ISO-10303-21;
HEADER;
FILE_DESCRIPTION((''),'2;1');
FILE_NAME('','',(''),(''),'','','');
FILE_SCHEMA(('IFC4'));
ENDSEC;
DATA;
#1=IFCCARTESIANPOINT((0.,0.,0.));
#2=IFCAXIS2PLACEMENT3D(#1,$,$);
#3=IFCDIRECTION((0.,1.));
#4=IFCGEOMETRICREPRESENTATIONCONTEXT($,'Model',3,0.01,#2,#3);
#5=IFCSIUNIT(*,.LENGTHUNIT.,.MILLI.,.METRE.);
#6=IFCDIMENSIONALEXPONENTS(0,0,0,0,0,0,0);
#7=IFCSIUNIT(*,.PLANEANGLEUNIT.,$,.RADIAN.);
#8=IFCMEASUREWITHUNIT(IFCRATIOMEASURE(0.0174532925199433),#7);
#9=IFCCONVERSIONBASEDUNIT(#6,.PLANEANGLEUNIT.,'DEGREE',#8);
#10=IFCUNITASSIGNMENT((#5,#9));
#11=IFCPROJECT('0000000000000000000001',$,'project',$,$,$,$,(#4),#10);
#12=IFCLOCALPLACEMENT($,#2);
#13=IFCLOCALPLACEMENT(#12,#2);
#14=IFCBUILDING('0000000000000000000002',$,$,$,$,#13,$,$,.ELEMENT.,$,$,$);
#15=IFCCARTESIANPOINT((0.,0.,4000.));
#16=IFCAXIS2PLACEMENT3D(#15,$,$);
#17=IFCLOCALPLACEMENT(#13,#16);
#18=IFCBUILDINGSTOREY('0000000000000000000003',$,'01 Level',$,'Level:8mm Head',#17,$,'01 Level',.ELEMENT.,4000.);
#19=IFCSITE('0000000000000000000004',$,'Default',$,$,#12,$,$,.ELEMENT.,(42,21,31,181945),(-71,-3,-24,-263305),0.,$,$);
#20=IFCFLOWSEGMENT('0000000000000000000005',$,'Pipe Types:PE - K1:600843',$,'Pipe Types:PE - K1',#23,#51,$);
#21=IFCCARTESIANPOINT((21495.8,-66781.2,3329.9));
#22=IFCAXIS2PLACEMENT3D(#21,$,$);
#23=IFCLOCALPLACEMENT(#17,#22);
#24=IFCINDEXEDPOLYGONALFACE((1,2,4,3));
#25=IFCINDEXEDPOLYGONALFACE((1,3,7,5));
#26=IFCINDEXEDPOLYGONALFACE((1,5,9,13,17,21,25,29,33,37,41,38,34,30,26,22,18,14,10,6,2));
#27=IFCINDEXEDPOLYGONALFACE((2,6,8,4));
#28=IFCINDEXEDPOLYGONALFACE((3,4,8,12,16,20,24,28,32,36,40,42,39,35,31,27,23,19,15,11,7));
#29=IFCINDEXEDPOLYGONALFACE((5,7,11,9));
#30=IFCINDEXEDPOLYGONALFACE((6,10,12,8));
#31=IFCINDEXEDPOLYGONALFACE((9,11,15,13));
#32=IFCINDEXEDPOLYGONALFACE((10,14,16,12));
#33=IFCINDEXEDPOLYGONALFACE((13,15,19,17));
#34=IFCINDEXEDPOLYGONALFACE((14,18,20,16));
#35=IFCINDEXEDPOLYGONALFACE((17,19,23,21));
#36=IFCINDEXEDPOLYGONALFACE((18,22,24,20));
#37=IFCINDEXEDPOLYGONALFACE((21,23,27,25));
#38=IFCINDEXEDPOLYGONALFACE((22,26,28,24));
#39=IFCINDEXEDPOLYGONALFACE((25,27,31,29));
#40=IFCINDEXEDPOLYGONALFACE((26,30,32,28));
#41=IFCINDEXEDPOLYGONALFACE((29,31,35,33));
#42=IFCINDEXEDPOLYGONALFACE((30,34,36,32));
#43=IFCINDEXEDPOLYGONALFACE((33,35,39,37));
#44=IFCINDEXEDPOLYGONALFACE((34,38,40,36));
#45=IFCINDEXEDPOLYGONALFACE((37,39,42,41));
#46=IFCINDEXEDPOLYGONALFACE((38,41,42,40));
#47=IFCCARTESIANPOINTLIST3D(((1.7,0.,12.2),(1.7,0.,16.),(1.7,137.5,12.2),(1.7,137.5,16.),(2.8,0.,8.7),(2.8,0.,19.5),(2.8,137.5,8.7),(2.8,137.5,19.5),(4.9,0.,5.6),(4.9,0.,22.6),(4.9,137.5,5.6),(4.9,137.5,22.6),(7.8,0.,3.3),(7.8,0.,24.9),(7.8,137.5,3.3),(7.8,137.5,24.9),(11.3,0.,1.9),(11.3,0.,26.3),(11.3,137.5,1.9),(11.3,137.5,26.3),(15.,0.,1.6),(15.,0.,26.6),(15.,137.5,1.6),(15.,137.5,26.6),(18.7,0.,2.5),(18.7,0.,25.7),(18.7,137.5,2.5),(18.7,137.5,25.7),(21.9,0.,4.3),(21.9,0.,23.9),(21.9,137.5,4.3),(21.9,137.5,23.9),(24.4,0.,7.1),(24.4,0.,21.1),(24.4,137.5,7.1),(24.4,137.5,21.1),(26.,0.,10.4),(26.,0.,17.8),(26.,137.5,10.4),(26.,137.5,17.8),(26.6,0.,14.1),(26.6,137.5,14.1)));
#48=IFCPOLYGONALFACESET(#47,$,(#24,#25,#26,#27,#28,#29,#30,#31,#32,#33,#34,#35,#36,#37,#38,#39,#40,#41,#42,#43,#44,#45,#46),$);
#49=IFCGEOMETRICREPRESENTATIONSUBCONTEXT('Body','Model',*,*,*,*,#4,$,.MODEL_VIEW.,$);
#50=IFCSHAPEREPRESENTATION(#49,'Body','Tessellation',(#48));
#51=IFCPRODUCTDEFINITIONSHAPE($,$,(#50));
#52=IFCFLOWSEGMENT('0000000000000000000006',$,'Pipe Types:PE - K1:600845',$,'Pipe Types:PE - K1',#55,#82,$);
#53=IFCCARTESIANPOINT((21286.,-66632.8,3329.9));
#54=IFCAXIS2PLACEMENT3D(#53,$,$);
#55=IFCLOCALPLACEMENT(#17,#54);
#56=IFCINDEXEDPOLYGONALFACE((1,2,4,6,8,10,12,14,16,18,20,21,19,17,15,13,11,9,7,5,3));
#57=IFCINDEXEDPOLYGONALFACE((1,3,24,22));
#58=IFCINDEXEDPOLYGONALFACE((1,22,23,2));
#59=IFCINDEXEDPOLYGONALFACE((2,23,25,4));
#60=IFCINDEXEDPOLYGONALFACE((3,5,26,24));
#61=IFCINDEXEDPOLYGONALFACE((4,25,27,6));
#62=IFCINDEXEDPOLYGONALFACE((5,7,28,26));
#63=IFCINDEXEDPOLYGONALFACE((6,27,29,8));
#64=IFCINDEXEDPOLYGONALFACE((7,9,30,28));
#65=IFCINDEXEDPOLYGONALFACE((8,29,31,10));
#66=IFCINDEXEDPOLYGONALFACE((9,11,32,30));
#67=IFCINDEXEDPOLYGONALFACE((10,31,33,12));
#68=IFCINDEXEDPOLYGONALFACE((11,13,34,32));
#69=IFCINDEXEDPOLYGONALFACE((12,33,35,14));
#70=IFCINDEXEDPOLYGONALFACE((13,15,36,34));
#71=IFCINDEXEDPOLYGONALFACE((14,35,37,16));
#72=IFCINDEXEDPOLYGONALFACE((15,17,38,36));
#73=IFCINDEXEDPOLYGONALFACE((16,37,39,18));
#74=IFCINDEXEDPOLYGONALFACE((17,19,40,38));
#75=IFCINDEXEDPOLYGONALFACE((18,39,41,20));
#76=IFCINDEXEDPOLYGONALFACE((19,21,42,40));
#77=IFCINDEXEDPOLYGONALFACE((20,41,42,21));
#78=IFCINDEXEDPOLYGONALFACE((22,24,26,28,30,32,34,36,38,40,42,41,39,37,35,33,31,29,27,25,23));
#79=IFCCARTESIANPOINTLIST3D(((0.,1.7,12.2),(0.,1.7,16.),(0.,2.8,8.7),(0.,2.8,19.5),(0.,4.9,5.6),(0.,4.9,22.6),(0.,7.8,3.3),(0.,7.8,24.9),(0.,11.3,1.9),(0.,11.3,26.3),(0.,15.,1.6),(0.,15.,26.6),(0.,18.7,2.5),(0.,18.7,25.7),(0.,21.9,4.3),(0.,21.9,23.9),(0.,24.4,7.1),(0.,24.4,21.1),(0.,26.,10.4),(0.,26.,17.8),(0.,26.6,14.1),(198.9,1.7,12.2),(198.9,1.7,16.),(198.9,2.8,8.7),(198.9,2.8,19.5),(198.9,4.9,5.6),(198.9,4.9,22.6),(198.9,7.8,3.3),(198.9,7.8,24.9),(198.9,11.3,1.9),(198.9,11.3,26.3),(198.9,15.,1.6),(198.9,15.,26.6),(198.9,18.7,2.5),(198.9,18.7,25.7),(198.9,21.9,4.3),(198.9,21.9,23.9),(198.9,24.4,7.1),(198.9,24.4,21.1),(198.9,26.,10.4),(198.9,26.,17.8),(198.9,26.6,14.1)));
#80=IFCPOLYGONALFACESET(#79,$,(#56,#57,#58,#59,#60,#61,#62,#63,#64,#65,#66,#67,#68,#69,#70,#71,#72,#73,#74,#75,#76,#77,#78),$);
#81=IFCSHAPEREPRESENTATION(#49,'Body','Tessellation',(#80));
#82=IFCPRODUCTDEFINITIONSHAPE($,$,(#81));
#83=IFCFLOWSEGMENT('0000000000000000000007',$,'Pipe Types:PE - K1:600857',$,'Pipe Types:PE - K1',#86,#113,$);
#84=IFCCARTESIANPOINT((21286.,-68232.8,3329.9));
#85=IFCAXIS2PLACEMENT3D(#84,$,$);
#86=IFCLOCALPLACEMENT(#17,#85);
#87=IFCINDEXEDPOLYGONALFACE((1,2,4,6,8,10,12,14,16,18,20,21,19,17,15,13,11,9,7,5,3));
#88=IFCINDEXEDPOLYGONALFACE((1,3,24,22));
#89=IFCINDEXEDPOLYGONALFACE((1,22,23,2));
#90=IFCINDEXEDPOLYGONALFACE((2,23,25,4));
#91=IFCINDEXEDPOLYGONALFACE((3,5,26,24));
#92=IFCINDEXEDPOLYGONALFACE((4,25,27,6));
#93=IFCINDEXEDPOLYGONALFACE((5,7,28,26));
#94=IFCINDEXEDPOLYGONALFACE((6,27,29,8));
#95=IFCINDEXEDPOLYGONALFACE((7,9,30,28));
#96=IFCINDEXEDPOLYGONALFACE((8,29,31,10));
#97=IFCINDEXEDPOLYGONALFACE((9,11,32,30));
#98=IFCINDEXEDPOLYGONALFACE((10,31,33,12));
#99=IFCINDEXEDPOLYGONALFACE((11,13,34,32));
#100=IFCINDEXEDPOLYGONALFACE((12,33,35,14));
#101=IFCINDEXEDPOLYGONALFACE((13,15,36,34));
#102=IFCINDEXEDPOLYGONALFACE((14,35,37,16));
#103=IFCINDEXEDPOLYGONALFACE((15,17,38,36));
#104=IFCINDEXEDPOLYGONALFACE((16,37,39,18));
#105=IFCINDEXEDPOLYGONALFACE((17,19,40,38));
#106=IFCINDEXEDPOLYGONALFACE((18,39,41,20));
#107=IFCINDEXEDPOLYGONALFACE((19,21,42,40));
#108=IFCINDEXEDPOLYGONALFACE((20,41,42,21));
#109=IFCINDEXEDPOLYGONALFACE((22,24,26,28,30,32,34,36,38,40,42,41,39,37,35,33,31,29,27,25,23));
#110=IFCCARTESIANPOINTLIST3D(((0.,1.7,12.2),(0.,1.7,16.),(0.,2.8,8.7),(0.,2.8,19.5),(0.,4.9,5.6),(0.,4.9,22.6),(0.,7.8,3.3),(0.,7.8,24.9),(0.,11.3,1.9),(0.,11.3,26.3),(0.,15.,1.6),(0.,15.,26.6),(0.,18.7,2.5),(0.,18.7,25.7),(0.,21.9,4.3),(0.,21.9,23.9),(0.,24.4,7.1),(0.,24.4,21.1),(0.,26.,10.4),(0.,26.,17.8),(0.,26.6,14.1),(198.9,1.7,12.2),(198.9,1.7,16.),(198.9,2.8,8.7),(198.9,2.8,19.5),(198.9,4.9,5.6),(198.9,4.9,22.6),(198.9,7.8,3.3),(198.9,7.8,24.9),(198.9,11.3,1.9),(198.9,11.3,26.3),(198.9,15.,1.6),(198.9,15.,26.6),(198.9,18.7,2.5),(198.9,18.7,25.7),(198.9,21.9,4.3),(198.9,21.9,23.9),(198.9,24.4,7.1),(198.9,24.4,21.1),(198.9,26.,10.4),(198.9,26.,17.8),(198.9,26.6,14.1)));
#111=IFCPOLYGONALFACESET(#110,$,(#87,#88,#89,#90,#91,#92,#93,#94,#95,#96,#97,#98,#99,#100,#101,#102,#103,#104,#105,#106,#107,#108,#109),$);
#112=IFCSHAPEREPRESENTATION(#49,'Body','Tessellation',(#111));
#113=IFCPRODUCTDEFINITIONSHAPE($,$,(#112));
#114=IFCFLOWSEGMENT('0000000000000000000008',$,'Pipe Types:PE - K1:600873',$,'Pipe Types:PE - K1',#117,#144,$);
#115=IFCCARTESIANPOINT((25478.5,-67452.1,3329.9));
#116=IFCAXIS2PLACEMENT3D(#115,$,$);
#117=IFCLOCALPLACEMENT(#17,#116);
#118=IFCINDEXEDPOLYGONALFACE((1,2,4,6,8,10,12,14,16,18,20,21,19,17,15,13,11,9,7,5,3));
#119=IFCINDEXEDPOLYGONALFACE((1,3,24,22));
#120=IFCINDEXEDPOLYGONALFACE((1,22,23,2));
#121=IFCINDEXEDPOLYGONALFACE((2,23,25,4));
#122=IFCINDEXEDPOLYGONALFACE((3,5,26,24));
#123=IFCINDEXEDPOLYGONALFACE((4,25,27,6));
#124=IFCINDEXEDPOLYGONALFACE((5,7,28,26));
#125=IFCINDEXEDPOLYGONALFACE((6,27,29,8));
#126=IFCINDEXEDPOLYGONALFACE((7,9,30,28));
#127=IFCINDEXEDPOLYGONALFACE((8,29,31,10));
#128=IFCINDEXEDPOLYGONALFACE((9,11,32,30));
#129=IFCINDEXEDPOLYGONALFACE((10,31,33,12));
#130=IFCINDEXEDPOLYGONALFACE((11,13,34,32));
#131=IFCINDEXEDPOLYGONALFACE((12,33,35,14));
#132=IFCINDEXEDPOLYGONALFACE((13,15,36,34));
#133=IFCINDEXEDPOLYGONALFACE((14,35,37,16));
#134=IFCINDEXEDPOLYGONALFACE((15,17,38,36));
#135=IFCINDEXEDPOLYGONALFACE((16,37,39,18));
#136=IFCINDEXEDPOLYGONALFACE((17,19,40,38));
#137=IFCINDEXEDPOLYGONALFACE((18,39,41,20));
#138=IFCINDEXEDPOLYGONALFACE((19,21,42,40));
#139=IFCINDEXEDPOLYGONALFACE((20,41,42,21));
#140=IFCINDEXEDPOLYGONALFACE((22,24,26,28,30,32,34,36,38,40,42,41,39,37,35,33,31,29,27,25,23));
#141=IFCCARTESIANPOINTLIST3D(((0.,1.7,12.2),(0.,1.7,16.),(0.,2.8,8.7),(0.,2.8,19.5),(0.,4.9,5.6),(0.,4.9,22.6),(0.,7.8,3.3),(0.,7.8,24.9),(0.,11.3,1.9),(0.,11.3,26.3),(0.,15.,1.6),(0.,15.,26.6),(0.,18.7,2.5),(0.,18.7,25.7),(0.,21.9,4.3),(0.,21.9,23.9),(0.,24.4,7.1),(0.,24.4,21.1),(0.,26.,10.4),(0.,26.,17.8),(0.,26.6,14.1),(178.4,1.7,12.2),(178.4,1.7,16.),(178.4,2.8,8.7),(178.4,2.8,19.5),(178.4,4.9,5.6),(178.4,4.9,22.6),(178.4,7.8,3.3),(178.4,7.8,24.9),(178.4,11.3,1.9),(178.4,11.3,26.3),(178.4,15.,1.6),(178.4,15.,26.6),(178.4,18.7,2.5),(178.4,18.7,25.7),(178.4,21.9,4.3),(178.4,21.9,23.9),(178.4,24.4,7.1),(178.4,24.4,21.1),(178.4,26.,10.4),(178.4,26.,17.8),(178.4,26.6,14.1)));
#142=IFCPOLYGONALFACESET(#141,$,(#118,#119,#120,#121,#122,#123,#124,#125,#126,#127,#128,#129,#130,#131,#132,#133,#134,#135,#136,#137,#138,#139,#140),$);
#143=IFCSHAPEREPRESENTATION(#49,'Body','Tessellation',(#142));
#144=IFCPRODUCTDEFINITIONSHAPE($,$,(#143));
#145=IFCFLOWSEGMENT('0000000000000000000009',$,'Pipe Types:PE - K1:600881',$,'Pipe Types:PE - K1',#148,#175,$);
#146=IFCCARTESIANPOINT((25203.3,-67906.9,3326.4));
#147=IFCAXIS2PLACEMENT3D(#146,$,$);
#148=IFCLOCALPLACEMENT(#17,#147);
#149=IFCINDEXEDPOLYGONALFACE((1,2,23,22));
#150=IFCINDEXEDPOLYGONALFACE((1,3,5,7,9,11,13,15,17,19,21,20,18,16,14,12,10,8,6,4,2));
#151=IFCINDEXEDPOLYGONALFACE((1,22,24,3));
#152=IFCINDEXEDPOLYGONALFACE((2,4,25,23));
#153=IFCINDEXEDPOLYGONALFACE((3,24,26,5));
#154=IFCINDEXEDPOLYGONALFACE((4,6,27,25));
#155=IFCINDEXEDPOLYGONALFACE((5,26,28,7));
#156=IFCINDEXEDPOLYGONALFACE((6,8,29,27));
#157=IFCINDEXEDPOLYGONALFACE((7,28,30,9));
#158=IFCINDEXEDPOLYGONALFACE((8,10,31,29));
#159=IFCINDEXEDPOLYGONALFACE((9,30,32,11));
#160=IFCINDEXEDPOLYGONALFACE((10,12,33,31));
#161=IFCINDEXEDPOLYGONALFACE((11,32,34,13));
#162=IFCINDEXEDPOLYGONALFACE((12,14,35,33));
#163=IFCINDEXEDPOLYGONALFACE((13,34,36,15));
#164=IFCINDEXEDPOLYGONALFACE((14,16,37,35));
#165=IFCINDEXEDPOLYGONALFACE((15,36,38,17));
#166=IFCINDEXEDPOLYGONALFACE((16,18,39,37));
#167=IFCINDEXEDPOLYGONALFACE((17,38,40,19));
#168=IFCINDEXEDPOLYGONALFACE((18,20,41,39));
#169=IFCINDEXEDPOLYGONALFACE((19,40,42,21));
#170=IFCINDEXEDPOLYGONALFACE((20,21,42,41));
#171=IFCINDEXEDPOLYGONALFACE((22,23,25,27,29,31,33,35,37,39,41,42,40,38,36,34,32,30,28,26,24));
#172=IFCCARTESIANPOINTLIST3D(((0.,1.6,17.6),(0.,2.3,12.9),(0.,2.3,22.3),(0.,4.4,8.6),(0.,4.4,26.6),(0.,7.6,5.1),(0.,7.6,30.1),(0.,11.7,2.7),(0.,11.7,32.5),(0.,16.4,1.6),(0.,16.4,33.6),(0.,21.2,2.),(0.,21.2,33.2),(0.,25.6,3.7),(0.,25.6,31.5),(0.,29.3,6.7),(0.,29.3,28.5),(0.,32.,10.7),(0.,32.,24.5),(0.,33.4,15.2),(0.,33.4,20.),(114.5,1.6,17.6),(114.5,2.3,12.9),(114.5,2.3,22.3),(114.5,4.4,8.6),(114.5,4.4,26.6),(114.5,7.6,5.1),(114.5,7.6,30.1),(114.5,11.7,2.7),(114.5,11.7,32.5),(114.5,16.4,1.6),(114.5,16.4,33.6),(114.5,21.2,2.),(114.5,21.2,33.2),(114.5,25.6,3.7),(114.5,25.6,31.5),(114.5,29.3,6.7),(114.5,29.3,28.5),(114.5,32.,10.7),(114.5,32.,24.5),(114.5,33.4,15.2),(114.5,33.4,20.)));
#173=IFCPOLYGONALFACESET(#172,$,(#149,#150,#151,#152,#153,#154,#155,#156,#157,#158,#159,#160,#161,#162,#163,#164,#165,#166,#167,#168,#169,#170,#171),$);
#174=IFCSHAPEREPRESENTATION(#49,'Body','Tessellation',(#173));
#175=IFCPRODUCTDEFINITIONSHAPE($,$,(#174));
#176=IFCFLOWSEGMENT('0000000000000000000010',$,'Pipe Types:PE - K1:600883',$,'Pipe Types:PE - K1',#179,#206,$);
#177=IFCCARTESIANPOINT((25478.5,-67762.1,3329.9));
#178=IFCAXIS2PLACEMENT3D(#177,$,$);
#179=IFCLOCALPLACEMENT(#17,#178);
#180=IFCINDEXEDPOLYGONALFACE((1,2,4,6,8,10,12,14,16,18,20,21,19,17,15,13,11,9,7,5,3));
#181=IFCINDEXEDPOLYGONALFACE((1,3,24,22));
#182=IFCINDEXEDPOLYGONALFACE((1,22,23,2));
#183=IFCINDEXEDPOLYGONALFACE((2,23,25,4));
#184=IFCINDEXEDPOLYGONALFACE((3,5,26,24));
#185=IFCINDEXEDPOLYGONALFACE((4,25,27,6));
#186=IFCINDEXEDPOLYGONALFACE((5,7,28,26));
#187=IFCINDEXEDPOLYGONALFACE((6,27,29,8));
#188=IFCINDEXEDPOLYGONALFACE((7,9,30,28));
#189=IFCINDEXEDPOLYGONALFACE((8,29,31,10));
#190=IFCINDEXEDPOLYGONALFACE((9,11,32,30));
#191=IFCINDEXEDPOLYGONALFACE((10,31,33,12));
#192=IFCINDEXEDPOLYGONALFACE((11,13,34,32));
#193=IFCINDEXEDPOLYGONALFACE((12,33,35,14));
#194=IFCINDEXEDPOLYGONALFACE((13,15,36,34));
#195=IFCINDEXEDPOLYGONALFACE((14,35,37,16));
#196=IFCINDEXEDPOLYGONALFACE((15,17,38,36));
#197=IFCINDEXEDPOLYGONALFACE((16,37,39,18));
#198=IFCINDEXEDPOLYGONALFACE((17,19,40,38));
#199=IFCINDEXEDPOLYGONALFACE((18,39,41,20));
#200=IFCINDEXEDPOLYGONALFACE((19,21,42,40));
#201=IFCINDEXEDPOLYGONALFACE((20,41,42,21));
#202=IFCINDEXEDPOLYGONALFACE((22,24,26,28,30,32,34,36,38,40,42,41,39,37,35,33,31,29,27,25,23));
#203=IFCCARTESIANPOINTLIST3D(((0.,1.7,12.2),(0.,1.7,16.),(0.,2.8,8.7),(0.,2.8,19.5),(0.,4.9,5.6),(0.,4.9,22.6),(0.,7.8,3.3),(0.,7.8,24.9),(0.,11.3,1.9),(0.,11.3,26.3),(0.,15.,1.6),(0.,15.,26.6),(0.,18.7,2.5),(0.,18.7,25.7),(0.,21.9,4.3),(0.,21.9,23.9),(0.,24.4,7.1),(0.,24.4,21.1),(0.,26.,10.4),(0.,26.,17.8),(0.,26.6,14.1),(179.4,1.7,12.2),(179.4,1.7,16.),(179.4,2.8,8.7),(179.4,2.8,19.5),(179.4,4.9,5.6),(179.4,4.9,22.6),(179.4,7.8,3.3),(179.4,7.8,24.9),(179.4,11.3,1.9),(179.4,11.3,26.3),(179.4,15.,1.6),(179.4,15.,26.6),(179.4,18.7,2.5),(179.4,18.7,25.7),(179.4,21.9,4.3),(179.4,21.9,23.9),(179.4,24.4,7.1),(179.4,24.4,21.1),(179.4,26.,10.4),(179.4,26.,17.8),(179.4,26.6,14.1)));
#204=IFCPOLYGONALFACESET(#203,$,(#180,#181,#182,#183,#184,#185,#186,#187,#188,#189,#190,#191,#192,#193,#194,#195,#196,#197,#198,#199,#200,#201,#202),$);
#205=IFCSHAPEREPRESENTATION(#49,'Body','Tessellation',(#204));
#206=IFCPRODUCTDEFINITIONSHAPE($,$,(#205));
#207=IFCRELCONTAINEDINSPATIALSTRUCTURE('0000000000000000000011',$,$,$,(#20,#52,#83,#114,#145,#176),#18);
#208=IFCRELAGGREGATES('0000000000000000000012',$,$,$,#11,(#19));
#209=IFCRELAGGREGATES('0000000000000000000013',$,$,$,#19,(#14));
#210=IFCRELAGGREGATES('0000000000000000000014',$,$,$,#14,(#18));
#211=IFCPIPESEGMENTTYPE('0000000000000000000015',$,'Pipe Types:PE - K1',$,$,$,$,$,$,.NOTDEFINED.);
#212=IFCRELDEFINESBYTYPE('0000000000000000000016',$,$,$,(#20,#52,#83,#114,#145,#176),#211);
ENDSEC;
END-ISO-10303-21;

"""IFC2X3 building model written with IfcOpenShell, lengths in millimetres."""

from ifc_helpers import new_model, entity, si_unit, converted_unit, direction, frame, frame_2d, origin, origin_2d_with_axis, place, context, subcontext, project, spatial, circle, extrude, type_object, element, save


model = new_model("IFC2X3")

# Units and contexts
model_context = context("Model", 3, precision=0.01, world=origin(), true_north=direction((0.0, 1.0)))
body_context = subcontext(model_context, "Body", "Model", "MODEL_VIEW")
ifc_project = project(units=[si_unit("LENGTHUNIT", "METRE", prefix="MILLI"), converted_unit("PLANEANGLEUNIT", "DEGREE", entity("IfcRatioMeasure", 0.0174532925199433), si_unit("PLANEANGLEUNIT", "RADIAN"), dimensions=[0, 0, 0, 0, 0, 0, 0])], contexts=[model_context])

# Site, building, storey
site_placement = place(None, origin())
site = spatial("IfcSite", under=ifc_project, at=site_placement, Name="Default", CompositionType="ELEMENT", RefLatitude=(42, 21, 31, 181945), RefLongitude=(-71, -3, -24, -263305), RefElevation=0.0)
building_placement = place(site_placement, origin())
building = spatial("IfcBuilding", under=site, at=building_placement, CompositionType="ELEMENT")
storey_placement = place(building_placement, frame((0.0, 0.0, 4000.0)))
storey = spatial("IfcBuildingStorey", under=building, at=storey_placement, Name="01 Level", ObjectType="Level:8mm Head", LongName="01 Level", CompositionType="ELEMENT", Elevation=4000.0)

# Flow segments
pipe_segment_type = type_object("IfcPipeSegmentType", Name="Pipe Types:PE - K1", PredefinedType="NOTDEFINED")
flow_segment_1_placement = place(storey_placement, frame((21495.8, -66781.2, 3329.9)))
element("IfcFlowSegment", 1, at=flow_segment_1_placement, inside=storey, type_object=pipe_segment_type, Name="Pipe Types:PE - K1:600843", ObjectType="Pipe Types:PE - K1", context=body_context, shape_type="SweptSolid", body=[
    extrude(circle(Radius=12.5, at=origin_2d_with_axis()), frame((14.1, 0.0, 14.1), z_axis=(0.0, 1.0, 0.0), x_axis=(1.0, 0.0, 0.0)), (0.0, 0.0, 1.0), 137.5),
])
flow_segment_2_placement = place(storey_placement, frame((21286.0, -66632.8, 3329.9)))
element("IfcFlowSegment", 2, at=flow_segment_2_placement, inside=storey, type_object=pipe_segment_type, Name="Pipe Types:PE - K1:600845", ObjectType="Pipe Types:PE - K1", context=body_context, shape_type="SweptSolid", body=[
    extrude(circle(Radius=12.5, at=frame_2d((0.0, 0.0), x_axis=(1.0, 0.0))), frame((0.0, 14.1, 14.1), z_axis=(1.0, 0.0, 0.0), x_axis=(0.0, 1.0, 0.0)), (0.0, 0.0, 1.0), 198.9),
])
flow_segment_3_placement = place(storey_placement, frame((21286.0, -68232.8, 3329.9)))
element("IfcFlowSegment", 3, at=flow_segment_3_placement, inside=storey, type_object=pipe_segment_type, Name="Pipe Types:PE - K1:600857", ObjectType="Pipe Types:PE - K1", context=body_context, shape_type="SweptSolid", body=[
    extrude(circle(Radius=12.5, at=frame_2d((0.0, 0.0), x_axis=(1.0, 0.0))), frame((0.0, 14.1, 14.1), z_axis=(1.0, 0.0, 0.0), x_axis=(0.0, 1.0, 0.0)), (0.0, 0.0, 1.0), 198.9),
])
flow_segment_4_placement = place(storey_placement, frame((25478.5, -67452.1, 3329.9)))
element("IfcFlowSegment", 4, at=flow_segment_4_placement, inside=storey, type_object=pipe_segment_type, Name="Pipe Types:PE - K1:600873", ObjectType="Pipe Types:PE - K1", context=body_context, shape_type="SweptSolid", body=[
    extrude(circle(Radius=12.5, at=frame_2d((0.0, 0.0), x_axis=(1.0, 0.0))), frame((0.0, 14.1, 14.1), z_axis=(1.0, 0.0, 0.0), x_axis=(0.0, 1.0, 0.0)), (0.0, 0.0, 1.0), 178.4),
])
flow_segment_5_placement = place(storey_placement, frame((25203.3, -67906.9, 3326.4)))
element("IfcFlowSegment", 5, at=flow_segment_5_placement, inside=storey, type_object=pipe_segment_type, Name="Pipe Types:PE - K1:600881", ObjectType="Pipe Types:PE - K1", context=body_context, shape_type="SweptSolid", body=[
    extrude(circle(Radius=16.0, at=origin_2d_with_axis()), frame((0.0, 17.6, 17.6), z_axis=(1.0, 0.0, 0.0), x_axis=(0.0, -1.0, 0.0)), (0.0, 0.0, 1.0), 114.5),
])
flow_segment_6_placement = place(storey_placement, frame((25478.5, -67762.1, 3329.9)))
element("IfcFlowSegment", 6, at=flow_segment_6_placement, inside=storey, type_object=pipe_segment_type, Name="Pipe Types:PE - K1:600883", ObjectType="Pipe Types:PE - K1", context=body_context, shape_type="SweptSolid", body=[
    extrude(circle(Radius=12.5, at=frame_2d((0.0, 0.0), x_axis=(1.0, 0.0))), frame((0.0, 14.1, 14.1), z_axis=(1.0, 0.0, 0.0), x_axis=(0.0, 1.0, 0.0)), (0.0, 0.0, 1.0), 179.4),
])

save(model, "model.ifc")
